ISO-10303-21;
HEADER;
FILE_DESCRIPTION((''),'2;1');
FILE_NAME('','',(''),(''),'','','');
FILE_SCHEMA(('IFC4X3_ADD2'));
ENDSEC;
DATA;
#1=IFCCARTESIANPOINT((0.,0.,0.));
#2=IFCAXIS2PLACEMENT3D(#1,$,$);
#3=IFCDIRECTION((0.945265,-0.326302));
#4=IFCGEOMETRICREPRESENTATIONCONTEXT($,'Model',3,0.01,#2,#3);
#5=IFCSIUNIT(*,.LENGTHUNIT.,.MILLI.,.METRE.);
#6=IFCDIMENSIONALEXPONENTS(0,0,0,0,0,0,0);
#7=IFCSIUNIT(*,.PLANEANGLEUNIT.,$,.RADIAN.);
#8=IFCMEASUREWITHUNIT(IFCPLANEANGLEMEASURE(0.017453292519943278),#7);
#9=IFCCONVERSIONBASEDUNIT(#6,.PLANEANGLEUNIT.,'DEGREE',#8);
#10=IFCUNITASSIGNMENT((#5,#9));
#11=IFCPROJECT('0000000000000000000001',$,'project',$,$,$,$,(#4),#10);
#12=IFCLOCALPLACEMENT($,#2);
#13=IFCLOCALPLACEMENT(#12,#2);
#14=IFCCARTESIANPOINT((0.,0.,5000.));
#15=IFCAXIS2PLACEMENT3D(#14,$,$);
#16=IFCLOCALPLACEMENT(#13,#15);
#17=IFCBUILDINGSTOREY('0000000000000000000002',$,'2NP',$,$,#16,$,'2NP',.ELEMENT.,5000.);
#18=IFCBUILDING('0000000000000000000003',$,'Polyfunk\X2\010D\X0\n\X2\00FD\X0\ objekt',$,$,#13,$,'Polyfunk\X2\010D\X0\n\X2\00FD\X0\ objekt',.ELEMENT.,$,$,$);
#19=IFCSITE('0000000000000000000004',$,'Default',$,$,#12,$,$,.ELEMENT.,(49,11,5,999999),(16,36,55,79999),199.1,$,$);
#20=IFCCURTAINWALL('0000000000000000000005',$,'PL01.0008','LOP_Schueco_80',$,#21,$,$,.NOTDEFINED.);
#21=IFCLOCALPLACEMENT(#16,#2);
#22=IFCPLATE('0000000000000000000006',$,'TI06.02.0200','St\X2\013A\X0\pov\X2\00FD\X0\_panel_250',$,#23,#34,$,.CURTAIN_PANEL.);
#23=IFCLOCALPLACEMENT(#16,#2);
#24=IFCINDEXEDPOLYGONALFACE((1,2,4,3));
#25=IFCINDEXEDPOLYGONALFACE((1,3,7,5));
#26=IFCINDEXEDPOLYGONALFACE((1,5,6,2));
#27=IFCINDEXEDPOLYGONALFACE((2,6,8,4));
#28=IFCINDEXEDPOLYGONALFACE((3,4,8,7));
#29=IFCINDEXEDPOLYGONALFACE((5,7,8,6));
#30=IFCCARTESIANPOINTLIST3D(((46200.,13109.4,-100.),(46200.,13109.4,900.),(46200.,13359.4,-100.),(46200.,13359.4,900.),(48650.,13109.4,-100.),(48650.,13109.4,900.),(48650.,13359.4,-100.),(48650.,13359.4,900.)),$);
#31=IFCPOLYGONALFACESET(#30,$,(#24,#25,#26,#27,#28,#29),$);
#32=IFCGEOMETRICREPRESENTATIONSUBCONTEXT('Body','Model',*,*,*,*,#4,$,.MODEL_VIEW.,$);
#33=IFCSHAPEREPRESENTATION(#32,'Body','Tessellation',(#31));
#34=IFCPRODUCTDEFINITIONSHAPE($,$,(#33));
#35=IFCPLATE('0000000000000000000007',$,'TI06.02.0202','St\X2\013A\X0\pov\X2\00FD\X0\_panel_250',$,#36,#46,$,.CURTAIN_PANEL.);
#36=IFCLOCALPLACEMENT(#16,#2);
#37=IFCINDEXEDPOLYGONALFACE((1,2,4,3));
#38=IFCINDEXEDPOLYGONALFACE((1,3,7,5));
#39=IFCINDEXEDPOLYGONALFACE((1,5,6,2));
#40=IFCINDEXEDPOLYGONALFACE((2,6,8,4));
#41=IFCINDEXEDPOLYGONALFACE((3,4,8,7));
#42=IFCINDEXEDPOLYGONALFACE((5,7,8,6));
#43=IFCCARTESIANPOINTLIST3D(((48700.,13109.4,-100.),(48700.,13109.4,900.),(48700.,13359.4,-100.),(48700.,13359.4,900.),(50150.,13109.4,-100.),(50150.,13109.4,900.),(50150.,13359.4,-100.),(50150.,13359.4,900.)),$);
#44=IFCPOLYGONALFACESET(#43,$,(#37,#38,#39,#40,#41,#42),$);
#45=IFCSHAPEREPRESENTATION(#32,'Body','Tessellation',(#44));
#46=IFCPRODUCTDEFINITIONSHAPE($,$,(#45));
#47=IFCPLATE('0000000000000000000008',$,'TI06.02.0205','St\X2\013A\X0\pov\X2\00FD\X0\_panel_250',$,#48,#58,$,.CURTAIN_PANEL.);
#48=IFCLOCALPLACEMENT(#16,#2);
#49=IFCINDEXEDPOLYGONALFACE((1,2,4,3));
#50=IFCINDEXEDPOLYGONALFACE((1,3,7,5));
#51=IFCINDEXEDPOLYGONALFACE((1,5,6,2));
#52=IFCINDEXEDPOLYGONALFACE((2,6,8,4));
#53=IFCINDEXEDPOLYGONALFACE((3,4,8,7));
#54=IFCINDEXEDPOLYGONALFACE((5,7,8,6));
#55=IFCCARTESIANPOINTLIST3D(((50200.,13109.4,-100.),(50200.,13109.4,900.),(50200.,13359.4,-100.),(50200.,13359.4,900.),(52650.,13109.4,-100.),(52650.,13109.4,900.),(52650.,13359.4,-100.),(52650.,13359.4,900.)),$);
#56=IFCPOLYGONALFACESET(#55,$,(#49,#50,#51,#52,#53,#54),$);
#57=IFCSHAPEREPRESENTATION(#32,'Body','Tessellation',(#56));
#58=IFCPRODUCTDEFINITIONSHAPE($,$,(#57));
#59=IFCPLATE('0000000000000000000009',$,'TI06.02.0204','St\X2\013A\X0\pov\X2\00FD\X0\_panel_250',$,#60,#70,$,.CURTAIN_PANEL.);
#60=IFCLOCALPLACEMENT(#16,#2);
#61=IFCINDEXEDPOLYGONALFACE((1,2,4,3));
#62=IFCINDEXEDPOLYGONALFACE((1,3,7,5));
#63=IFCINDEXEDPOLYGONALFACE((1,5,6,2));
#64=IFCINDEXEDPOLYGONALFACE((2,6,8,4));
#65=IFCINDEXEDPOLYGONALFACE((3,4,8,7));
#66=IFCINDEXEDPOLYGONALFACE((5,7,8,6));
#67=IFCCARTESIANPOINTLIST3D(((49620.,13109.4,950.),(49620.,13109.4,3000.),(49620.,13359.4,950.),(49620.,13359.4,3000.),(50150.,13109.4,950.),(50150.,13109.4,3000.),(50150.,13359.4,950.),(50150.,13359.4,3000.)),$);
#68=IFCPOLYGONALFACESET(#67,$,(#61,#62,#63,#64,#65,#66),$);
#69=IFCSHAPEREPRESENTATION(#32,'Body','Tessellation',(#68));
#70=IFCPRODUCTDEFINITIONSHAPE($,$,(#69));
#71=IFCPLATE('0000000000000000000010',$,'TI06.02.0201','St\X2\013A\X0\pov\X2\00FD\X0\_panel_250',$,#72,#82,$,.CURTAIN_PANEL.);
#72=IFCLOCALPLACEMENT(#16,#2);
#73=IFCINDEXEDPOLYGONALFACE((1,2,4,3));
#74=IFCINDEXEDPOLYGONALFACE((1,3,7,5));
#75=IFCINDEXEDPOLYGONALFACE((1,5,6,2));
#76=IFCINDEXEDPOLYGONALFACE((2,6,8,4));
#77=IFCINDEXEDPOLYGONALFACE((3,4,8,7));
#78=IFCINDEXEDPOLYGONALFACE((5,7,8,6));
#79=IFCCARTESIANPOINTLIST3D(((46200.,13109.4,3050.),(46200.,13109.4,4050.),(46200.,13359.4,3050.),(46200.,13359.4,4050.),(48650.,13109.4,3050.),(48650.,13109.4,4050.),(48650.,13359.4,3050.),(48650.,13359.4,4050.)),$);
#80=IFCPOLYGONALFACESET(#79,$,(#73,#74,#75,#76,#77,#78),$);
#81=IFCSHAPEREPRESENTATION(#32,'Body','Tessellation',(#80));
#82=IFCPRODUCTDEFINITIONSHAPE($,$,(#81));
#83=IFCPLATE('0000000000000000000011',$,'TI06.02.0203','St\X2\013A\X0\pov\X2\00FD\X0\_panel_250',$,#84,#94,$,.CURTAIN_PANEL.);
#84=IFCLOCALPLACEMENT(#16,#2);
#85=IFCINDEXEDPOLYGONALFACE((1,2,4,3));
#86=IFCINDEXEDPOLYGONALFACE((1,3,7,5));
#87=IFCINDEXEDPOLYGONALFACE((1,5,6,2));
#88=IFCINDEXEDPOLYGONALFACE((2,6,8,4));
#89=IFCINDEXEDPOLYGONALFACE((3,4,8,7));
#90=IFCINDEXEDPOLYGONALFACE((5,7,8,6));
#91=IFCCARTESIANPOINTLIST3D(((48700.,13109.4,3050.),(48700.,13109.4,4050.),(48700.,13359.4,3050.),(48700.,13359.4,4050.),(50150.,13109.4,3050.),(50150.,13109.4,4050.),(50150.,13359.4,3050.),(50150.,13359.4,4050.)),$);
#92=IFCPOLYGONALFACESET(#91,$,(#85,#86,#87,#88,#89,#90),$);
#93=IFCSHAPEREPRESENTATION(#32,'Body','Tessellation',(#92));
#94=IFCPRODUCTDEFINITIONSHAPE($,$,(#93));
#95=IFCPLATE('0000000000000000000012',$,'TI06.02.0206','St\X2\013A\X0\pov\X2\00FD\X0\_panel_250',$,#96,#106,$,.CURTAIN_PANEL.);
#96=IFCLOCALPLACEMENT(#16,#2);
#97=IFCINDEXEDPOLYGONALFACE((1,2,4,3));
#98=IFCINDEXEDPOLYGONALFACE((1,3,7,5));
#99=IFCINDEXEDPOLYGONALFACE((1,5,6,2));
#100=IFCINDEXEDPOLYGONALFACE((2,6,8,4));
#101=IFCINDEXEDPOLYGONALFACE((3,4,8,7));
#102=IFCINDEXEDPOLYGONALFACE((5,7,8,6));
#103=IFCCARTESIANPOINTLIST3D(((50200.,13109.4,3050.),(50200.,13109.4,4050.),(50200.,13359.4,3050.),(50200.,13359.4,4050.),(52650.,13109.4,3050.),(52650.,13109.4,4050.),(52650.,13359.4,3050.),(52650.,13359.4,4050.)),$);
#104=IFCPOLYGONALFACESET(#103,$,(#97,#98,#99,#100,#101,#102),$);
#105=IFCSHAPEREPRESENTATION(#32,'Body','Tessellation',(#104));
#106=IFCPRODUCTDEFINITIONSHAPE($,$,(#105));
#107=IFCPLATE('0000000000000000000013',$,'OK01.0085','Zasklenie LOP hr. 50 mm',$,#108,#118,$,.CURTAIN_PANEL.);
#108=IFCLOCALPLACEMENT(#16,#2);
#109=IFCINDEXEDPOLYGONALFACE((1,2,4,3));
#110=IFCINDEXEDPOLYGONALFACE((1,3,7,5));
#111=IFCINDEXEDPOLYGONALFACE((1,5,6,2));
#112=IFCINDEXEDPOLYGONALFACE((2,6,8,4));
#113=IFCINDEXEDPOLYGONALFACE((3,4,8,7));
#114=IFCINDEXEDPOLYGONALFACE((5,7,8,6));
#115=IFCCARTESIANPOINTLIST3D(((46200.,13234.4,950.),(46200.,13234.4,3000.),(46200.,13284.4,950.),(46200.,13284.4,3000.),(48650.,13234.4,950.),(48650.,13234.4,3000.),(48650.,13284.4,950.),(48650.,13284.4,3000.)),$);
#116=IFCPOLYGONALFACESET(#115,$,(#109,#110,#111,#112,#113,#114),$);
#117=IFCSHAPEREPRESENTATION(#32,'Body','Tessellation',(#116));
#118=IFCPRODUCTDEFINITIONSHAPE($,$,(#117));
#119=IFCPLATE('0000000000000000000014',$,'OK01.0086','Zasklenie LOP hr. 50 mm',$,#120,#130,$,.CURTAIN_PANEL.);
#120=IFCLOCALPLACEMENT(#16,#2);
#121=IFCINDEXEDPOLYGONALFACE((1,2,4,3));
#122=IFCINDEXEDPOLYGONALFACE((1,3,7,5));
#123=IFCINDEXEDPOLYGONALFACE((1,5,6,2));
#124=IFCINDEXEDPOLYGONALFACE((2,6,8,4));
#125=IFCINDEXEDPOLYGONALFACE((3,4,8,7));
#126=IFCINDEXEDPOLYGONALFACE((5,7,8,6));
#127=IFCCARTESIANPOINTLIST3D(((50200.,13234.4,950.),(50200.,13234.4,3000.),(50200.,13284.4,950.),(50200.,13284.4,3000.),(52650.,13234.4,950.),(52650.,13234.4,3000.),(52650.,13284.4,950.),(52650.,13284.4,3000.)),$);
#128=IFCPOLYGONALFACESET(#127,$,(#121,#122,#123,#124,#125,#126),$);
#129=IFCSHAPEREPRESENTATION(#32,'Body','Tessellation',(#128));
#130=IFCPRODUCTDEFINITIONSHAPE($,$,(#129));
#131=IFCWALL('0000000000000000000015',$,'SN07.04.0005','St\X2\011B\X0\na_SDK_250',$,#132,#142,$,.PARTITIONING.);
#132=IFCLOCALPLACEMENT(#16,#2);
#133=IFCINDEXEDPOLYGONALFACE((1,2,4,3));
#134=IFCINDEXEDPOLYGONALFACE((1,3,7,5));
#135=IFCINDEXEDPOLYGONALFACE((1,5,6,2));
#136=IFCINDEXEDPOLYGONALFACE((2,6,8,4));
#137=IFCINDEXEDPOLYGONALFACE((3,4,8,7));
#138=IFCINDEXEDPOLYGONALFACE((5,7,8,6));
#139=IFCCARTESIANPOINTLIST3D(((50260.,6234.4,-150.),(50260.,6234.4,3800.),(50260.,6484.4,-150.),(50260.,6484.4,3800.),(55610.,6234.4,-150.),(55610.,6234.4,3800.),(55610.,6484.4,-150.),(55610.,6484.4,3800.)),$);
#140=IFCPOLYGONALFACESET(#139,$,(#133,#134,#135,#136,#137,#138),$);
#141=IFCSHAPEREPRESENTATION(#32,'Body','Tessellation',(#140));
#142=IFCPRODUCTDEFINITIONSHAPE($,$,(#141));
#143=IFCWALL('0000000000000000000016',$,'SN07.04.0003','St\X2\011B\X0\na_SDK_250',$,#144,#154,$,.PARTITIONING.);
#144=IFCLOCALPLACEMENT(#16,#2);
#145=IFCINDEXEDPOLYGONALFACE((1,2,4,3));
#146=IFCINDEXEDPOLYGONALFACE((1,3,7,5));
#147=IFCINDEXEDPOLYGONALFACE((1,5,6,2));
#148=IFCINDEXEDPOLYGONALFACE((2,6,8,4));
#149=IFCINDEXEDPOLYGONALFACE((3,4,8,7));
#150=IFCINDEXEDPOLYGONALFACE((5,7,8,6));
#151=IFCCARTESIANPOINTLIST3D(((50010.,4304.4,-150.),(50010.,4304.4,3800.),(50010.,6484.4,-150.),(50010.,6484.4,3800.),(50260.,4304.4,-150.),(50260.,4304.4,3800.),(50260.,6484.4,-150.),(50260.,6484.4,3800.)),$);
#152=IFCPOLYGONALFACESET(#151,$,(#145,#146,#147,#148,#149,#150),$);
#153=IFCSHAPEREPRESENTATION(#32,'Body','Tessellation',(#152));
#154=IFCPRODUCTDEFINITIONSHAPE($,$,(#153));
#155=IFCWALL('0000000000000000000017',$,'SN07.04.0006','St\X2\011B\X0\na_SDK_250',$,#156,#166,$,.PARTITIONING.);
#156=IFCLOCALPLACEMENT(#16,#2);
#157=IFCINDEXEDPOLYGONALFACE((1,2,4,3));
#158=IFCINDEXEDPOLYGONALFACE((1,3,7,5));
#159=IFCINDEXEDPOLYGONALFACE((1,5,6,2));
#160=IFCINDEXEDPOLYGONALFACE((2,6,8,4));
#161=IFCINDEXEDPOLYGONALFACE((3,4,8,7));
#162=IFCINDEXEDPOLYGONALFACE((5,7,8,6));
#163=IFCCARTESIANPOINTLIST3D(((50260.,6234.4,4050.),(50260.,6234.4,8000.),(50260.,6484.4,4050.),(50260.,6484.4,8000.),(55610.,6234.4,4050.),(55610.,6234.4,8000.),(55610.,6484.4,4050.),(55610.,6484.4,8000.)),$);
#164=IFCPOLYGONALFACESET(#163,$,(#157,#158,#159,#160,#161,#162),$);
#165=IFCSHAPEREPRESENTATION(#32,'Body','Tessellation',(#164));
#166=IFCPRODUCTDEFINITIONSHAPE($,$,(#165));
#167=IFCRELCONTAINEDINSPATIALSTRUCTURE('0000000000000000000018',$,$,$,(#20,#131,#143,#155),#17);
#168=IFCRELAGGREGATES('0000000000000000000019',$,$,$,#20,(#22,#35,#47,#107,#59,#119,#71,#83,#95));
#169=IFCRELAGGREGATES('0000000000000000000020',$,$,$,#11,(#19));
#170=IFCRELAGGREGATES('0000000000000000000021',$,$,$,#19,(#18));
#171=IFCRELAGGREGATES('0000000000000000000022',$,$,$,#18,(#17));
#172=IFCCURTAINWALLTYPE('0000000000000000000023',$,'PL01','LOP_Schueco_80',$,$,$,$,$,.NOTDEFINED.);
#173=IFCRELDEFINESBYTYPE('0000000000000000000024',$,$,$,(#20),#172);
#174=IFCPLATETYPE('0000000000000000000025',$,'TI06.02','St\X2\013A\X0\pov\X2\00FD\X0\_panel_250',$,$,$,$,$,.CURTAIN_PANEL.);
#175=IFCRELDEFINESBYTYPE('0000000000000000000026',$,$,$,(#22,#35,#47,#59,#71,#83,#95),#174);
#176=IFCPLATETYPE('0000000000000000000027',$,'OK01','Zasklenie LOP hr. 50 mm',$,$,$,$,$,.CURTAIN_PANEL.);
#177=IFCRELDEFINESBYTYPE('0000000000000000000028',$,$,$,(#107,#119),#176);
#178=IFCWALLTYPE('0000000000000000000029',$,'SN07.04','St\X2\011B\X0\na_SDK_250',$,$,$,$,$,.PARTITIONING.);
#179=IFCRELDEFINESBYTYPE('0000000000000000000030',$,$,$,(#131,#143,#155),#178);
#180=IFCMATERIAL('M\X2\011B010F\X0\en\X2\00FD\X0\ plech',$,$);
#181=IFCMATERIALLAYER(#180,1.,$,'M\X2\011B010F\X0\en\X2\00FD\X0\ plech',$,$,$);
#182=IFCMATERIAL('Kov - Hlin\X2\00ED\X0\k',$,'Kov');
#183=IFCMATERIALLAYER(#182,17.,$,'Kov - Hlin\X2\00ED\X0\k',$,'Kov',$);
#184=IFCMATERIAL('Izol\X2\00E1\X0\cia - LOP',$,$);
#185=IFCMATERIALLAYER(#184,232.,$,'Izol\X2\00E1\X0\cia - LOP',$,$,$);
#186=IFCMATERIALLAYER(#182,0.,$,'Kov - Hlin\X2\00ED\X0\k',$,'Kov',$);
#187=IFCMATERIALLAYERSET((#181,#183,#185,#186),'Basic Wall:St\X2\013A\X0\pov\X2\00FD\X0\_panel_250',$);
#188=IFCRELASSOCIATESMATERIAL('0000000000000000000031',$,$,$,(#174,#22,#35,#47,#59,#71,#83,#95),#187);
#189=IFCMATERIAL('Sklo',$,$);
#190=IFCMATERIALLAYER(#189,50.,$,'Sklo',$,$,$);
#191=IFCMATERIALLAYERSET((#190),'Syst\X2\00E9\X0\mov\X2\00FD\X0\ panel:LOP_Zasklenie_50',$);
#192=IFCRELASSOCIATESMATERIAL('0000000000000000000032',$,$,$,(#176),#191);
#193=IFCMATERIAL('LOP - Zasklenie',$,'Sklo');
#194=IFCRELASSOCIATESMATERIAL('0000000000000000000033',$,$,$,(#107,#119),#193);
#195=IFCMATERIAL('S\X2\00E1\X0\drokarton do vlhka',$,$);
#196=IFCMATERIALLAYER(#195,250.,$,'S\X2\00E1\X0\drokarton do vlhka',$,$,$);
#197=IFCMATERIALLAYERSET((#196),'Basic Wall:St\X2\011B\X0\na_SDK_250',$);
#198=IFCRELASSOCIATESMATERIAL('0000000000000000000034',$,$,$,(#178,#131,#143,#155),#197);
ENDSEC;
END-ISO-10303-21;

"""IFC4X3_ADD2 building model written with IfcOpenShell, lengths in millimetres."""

from ifc_helpers import new_model, entity, si_unit, converted_unit, direction, frame, frame_2d, origin, origin_2d_with_axis, place, context, subcontext, project, spatial, polyline, rectangle, extrude, clip, bounded_halfspace, source, transform, mapped, material, layer, layer_set, layer_usage, type_object, type_shapes, element, aggregate, save


model = new_model("IFC4X3_ADD2")

# Units and contexts
model_context = context("Model", 3, precision=0.01, world=origin(), true_north=direction((0.945265, -0.326302)))
body_context = subcontext(model_context, "Body", "Model", "MODEL_VIEW")
ifc_project = project(units=[si_unit("LENGTHUNIT", "METRE", prefix="MILLI"), converted_unit("PLANEANGLEUNIT", "DEGREE", entity("IfcPlaneAngleMeasure", 0.017453292519943278), si_unit("PLANEANGLEUNIT", "RADIAN"), dimensions=[0, 0, 0, 0, 0, 0, 0])], contexts=[model_context])

# Site, building, storey
site_placement = place(None, origin())
site = spatial("IfcSite", under=ifc_project, at=site_placement, Name="Default", CompositionType="ELEMENT", RefLatitude=(49, 11, 5, 999999), RefLongitude=(16, 36, 55, 79999), RefElevation=199.1)
building_placement = place(site_placement, origin())
building = spatial("IfcBuilding", under=site, at=building_placement, Name="Polyfunkčný objekt", LongName="Polyfunkčný objekt", CompositionType="ELEMENT")
storey_placement = place(building_placement, frame((0.0, 0.0, 5000.0)))
storey = spatial("IfcBuildingStorey", under=building, at=storey_placement, Name="2NP", LongName="2NP", CompositionType="ELEMENT", Elevation=5000.0)

# Curtain wall, plates
curtain_wall_type = type_object("IfcCurtainWallType", Name="PL01", Description="LOP_Schueco_80", PredefinedType="NOTDEFINED")
curtain_wall_placement = place(storey_placement, frame((0.0, 0.0, -5000.0)))
curtain_wall = element("IfcCurtainWall", 1, at=curtain_wall_placement, inside=storey, type_object=curtain_wall_type, Name="PL01.0008", Description="LOP_Schueco_80", PredefinedType="NOTDEFINED")
ifc_material_1 = material(Name="Měďený plech")
ifc_layer_1 = layer(ifc_material_1, 1.0, Name="Měďený plech")
ifc_material_2 = material(Name="Kov - Hliník", Category="Kov")
ifc_layer_2 = layer(ifc_material_2, 17.0, Name="Kov - Hliník", Category="Kov")
ifc_material_3 = material(Name="Izolácia - LOP")
ifc_layer_3 = layer(ifc_material_3, 232.0, Name="Izolácia - LOP")
ifc_layer_4 = layer(ifc_material_2, 0.0, Name="Kov - Hliník", Category="Kov")
ifc_layer_set_1 = layer_set([ifc_layer_1, ifc_layer_2, ifc_layer_3, ifc_layer_4], Name="Basic Wall:Stĺpový_panel_250")
ifc_layer_usage_1 = layer_usage(ifc_layer_set_1, "AXIS2", "NEGATIVE", 125.0)
plate_type_1 = type_object("IfcPlateType", Name="TI06.02", Description="Stĺpový_panel_250", PredefinedType="CURTAIN_PANEL", material=ifc_layer_set_1)
plate_1_placement = place(storey_placement, frame((46200.0, 13234.4, -100.0)))
plate_1 = element("IfcPlate", 2, at=plate_1_placement, type_object=plate_type_1, material=ifc_layer_usage_1, Name="TI06.02.0200", Description="Stĺpový_panel_250", PredefinedType="CURTAIN_PANEL", context=body_context, shape_type="SweptSolid", body=[
    extrude(rectangle(XDim=250.0, YDim=2450.0, at=frame_2d((0.0, 0.0), x_axis=(1.0, 0.0))), frame((1225.0, 0.0, 0.0), z_axis=(0.0, 0.0, 1.0), x_axis=(0.0, 1.0, 0.0)), (0.0, 0.0, 1.0), 1000.0),
])
ifc_layer_usage_2 = layer_usage(ifc_layer_set_1, "AXIS2", "NEGATIVE", 125.0)
plate_2_placement = place(storey_placement, frame((48700.0, 13234.4, -100.0)))
plate_2 = element("IfcPlate", 3, at=plate_2_placement, type_object=plate_type_1, material=ifc_layer_usage_2, Name="TI06.02.0202", Description="Stĺpový_panel_250", PredefinedType="CURTAIN_PANEL", context=body_context, shape_type="SweptSolid", body=[
    extrude(rectangle(XDim=250.0, YDim=1450.0, at=frame_2d((0.0, 0.0), x_axis=(1.0, 0.0))), frame((725.0, 0.0, 0.0), z_axis=(0.0, 0.0, 1.0), x_axis=(0.0, 1.0, 0.0)), (0.0, 0.0, 1.0), 1000.0),
])
ifc_layer_usage_3 = layer_usage(ifc_layer_set_1, "AXIS2", "NEGATIVE", 125.0)
plate_3_placement = place(storey_placement, frame((50200.0, 13234.4, -100.0)))
plate_3 = element("IfcPlate", 4, at=plate_3_placement, type_object=plate_type_1, material=ifc_layer_usage_3, Name="TI06.02.0205", Description="Stĺpový_panel_250", PredefinedType="CURTAIN_PANEL", context=body_context, shape_type="SweptSolid", body=[
    extrude(rectangle(XDim=250.0, YDim=2450.0, at=origin_2d_with_axis()), frame((1225.0, 0.0, 0.0), z_axis=(0.0, 0.0, 1.0), x_axis=(0.0, 1.0, 0.0)), (0.0, 0.0, 1.0), 1000.0),
])
ifc_layer_usage_4 = layer_usage(ifc_layer_set_1, "AXIS2", "NEGATIVE", 125.0)
plate_4_placement = place(storey_placement, frame((49620.0, 13234.4, 950.0)))
plate_4 = element("IfcPlate", 5, at=plate_4_placement, type_object=plate_type_1, material=ifc_layer_usage_4, Name="TI06.02.0204", Description="Stĺpový_panel_250", PredefinedType="CURTAIN_PANEL", context=body_context, shape_type="SweptSolid", body=[
    extrude(rectangle(XDim=250.0, YDim=530.0, at=frame_2d((0.0, 0.0), x_axis=(1.0, 0.0))), frame((265.0, 0.0, 0.0), z_axis=(0.0, 0.0, 1.0), x_axis=(0.0, 1.0, 0.0)), (0.0, 0.0, 1.0), 2050.0),
])
ifc_layer_usage_5 = layer_usage(ifc_layer_set_1, "AXIS2", "NEGATIVE", 125.0)
plate_5_placement = place(storey_placement, frame((46200.0, 13234.4, 3050.0)))
plate_5 = element("IfcPlate", 6, at=plate_5_placement, type_object=plate_type_1, material=ifc_layer_usage_5, Name="TI06.02.0201", Description="Stĺpový_panel_250", PredefinedType="CURTAIN_PANEL", context=body_context, shape_type="SweptSolid", body=[
    extrude(rectangle(XDim=250.0, YDim=2450.0, at=frame_2d((0.0, 0.0), x_axis=(1.0, 0.0))), frame((1225.0, 0.0, 0.0), z_axis=(0.0, 0.0, 1.0), x_axis=(0.0, 1.0, 0.0)), (0.0, 0.0, 1.0), 1000.0),
])
ifc_layer_usage_6 = layer_usage(ifc_layer_set_1, "AXIS2", "NEGATIVE", 125.0)
plate_6_placement = place(storey_placement, frame((48700.0, 13234.4, 3050.0)))
plate_6 = element("IfcPlate", 7, at=plate_6_placement, type_object=plate_type_1, material=ifc_layer_usage_6, Name="TI06.02.0203", Description="Stĺpový_panel_250", PredefinedType="CURTAIN_PANEL", context=body_context, shape_type="SweptSolid", body=[
    extrude(rectangle(XDim=250.0, YDim=1450.0, at=frame_2d((0.0, 0.0), x_axis=(1.0, 0.0))), frame((725.0, 0.0, 0.0), z_axis=(0.0, 0.0, 1.0), x_axis=(0.0, 1.0, 0.0)), (0.0, 0.0, 1.0), 1000.0),
])
ifc_layer_usage_7 = layer_usage(ifc_layer_set_1, "AXIS2", "NEGATIVE", 125.0)
plate_7_placement = place(storey_placement, frame((50200.0, 13234.4, 3050.0)))
plate_7 = element("IfcPlate", 8, at=plate_7_placement, type_object=plate_type_1, material=ifc_layer_usage_7, Name="TI06.02.0206", Description="Stĺpový_panel_250", PredefinedType="CURTAIN_PANEL", context=body_context, shape_type="SweptSolid", body=[
    extrude(rectangle(XDim=250.0, YDim=2450.0, at=origin_2d_with_axis()), frame((1225.0, 0.0, 0.0), z_axis=(0.0, 0.0, 1.0), x_axis=(0.0, 1.0, 0.0)), (0.0, 0.0, 1.0), 1000.0),
])
ifc_material_4 = material(Name="LOP - Zasklenie", Category="Sklo")
ifc_material_5 = material(Name="Sklo")
ifc_layer_5 = layer(ifc_material_5, 50.0, Name="Sklo")
ifc_layer_set_2 = layer_set([ifc_layer_5], Name="Systémový panel:LOP_Zasklenie_50")
plate_type_2 = type_object("IfcPlateType", Name="OK01", Description="Zasklenie LOP hr. 50 mm", PredefinedType="CURTAIN_PANEL", material=ifc_layer_set_2)
shared_shape_1 = source(origin(), body_context, "Body", "SweptSolid", [
    extrude(rectangle(XDim=50.0, YDim=2450.0, at=origin_2d_with_axis()), frame((0.0, 25.0, 0.0), z_axis=(0.0, 0.0, 1.0), x_axis=(0.0, 1.0, 0.0)), (0.0, 0.0, 1.0), 2050.0),
])
type_shapes(plate_type_2, [shared_shape_1])
plate_8_placement = place(curtain_wall_placement, frame((47425.0, 13234.4, 5950.0)))
plate_8 = element("IfcPlate", 9, at=plate_8_placement, type_object=plate_type_2, material=ifc_material_4, Name="OK01.0085", Description="Zasklenie LOP hr. 50 mm", PredefinedType="CURTAIN_PANEL", context=body_context, shape_type="MappedRepresentation", body=[
    mapped(shared_shape_1, transform((0.0, 0.0, 0.0), scale=1.0)),
])
plate_9_placement = place(curtain_wall_placement, frame((51425.0, 13234.4, 5950.0)))
plate_9 = element("IfcPlate", 10, at=plate_9_placement, type_object=plate_type_2, material=ifc_material_4, Name="OK01.0086", Description="Zasklenie LOP hr. 50 mm", PredefinedType="CURTAIN_PANEL", context=body_context, shape_type="MappedRepresentation", body=[
    mapped(shared_shape_1, transform((0.0, 0.0, 0.0), scale=1.0)),
])

# Walls
ifc_material_6 = material(Name="Sádrokarton do vlhka")
ifc_layer_6 = layer(ifc_material_6, 250.0, Name="Sádrokarton do vlhka")
ifc_layer_set_3 = layer_set([ifc_layer_6], Name="Basic Wall:Stěna_SDK_250")
wall_type_1 = type_object("IfcWallType", Name="SN07.04", Description="Stěna_SDK_250", PredefinedType="PARTITIONING", material=ifc_layer_set_3)
wall_1_placement = place(storey_placement, frame((50260.0, 6359.4, -150.0)))
element("IfcWall", 11, at=wall_1_placement, inside=storey, type_object=wall_type_1, material=ifc_layer_set_3, Name="SN07.04.0005", Description="Stěna_SDK_250", PredefinedType="PARTITIONING", context=body_context, shape_type="Clipping", body=[
    clip(clip(extrude(rectangle(XDim=5350.0, YDim=250.0, at=frame_2d((2675.0, 0.0), x_axis=(-1.0, 0.0))), origin(), (0.0, 0.0, 1.0), 3950.0), bounded_halfspace(frame((5350.0, -125.0, 0.0), z_axis=(0.0, 0.0, 1.0), x_axis=(-1.0, 0.0, 0.0)), True, frame((5350.0, -125.0, 0.0)), polyline([(0.0, 0.0), (0.0, 250.0), (-5350.0, 250.0), (-5350.0, 0.0), (-1670.0, 0.0), (-1520.0, 0.0), (0.0, 0.0)]))), bounded_halfspace(frame((0.0, -125.0, 3950.0), z_axis=(0.0, 0.0, -1.0), x_axis=(1.0, 0.0, 0.0)), True, frame((0.0, -125.0, 3950.0)), polyline([(0.0, 0.0), (3680.0, 0.0), (3830.0, 0.0), (5350.0, 0.0), (5350.0, 250.0), (0.0, 250.0), (0.0, 0.0)]))),
])
wall_2_placement = place(storey_placement, frame((50135.0, 6484.4, -150.0), z_axis=(0.0, 0.0, 1.0), x_axis=(0.0, -1.0, 0.0)))
element("IfcWall", 12, at=wall_2_placement, inside=storey, type_object=wall_type_1, material=ifc_layer_set_3, Name="SN07.04.0003", Description="Stěna_SDK_250", PredefinedType="PARTITIONING", context=body_context, shape_type="Clipping", body=[
    clip(clip(extrude(rectangle(XDim=2180.0, YDim=250.0, at=frame_2d((1090.0, 0.0), x_axis=(-1.0, 0.0))), origin(), (0.0, 0.0, 1.0), 3950.0), bounded_halfspace(frame((2180.0, -125.0, 0.0), z_axis=(0.0, 0.0, 1.0), x_axis=(0.0, -1.0, 0.0)), True, frame((2180.0, -125.0, 0.0)), polyline([(0.0, 0.0), (0.0, 250.0), (-1930.0, 250.0), (-2180.0, 250.0), (-2180.0, 0.0), (0.0, 0.0)]))), bounded_halfspace(frame((0.0, -125.0, 3950.0), z_axis=(0.0, 0.0, -1.0), x_axis=(0.0, 1.0, 0.0)), True, frame((0.0, -125.0, 3950.0)), polyline([(0.0, 0.0), (2180.0, 0.0), (2180.0, 250.0), (250.0, 250.0), (0.0, 250.0), (0.0, 0.0)]))),
])
wall_3_placement = place(storey_placement, frame((50260.0, 6359.4, 4050.0)))
element("IfcWall", 13, at=wall_3_placement, inside=storey, type_object=wall_type_1, material=ifc_layer_set_3, Name="SN07.04.0006", Description="Stěna_SDK_250", PredefinedType="PARTITIONING", context=body_context, shape_type="Clipping", body=[
    clip(clip(extrude(rectangle(XDim=5350.0, YDim=250.0, at=frame_2d((2675.0, 0.0), x_axis=(-1.0, 0.0))), origin(), (0.0, 0.0, 1.0), 3950.0), bounded_halfspace(frame((5350.0, -125.0, 0.0), z_axis=(0.0, 0.0, 1.0), x_axis=(-1.0, 0.0, 0.0)), True, frame((5350.0, -125.0, 0.0)), polyline([(0.0, 0.0), (0.0, 250.0), (-5350.0, 250.0), (-5350.0, 0.0), (-1670.0, 0.0), (-1520.0, 0.0), (0.0, 0.0)]))), bounded_halfspace(frame((0.0, -125.0, 3950.0), z_axis=(0.0, 0.0, -1.0), x_axis=(1.0, 0.0, 0.0)), True, frame((0.0, -125.0, 3950.0)), polyline([(0.0, 0.0), (3680.0, 0.0), (3830.0, 0.0), (5350.0, 0.0), (5350.0, 250.0), (0.0, 250.0), (0.0, 0.0)]))),
])

aggregate(curtain_wall, [plate_1, plate_2, plate_3, plate_8, plate_4, plate_9, plate_5, plate_6, plate_7])

save(model, "model.ifc")
